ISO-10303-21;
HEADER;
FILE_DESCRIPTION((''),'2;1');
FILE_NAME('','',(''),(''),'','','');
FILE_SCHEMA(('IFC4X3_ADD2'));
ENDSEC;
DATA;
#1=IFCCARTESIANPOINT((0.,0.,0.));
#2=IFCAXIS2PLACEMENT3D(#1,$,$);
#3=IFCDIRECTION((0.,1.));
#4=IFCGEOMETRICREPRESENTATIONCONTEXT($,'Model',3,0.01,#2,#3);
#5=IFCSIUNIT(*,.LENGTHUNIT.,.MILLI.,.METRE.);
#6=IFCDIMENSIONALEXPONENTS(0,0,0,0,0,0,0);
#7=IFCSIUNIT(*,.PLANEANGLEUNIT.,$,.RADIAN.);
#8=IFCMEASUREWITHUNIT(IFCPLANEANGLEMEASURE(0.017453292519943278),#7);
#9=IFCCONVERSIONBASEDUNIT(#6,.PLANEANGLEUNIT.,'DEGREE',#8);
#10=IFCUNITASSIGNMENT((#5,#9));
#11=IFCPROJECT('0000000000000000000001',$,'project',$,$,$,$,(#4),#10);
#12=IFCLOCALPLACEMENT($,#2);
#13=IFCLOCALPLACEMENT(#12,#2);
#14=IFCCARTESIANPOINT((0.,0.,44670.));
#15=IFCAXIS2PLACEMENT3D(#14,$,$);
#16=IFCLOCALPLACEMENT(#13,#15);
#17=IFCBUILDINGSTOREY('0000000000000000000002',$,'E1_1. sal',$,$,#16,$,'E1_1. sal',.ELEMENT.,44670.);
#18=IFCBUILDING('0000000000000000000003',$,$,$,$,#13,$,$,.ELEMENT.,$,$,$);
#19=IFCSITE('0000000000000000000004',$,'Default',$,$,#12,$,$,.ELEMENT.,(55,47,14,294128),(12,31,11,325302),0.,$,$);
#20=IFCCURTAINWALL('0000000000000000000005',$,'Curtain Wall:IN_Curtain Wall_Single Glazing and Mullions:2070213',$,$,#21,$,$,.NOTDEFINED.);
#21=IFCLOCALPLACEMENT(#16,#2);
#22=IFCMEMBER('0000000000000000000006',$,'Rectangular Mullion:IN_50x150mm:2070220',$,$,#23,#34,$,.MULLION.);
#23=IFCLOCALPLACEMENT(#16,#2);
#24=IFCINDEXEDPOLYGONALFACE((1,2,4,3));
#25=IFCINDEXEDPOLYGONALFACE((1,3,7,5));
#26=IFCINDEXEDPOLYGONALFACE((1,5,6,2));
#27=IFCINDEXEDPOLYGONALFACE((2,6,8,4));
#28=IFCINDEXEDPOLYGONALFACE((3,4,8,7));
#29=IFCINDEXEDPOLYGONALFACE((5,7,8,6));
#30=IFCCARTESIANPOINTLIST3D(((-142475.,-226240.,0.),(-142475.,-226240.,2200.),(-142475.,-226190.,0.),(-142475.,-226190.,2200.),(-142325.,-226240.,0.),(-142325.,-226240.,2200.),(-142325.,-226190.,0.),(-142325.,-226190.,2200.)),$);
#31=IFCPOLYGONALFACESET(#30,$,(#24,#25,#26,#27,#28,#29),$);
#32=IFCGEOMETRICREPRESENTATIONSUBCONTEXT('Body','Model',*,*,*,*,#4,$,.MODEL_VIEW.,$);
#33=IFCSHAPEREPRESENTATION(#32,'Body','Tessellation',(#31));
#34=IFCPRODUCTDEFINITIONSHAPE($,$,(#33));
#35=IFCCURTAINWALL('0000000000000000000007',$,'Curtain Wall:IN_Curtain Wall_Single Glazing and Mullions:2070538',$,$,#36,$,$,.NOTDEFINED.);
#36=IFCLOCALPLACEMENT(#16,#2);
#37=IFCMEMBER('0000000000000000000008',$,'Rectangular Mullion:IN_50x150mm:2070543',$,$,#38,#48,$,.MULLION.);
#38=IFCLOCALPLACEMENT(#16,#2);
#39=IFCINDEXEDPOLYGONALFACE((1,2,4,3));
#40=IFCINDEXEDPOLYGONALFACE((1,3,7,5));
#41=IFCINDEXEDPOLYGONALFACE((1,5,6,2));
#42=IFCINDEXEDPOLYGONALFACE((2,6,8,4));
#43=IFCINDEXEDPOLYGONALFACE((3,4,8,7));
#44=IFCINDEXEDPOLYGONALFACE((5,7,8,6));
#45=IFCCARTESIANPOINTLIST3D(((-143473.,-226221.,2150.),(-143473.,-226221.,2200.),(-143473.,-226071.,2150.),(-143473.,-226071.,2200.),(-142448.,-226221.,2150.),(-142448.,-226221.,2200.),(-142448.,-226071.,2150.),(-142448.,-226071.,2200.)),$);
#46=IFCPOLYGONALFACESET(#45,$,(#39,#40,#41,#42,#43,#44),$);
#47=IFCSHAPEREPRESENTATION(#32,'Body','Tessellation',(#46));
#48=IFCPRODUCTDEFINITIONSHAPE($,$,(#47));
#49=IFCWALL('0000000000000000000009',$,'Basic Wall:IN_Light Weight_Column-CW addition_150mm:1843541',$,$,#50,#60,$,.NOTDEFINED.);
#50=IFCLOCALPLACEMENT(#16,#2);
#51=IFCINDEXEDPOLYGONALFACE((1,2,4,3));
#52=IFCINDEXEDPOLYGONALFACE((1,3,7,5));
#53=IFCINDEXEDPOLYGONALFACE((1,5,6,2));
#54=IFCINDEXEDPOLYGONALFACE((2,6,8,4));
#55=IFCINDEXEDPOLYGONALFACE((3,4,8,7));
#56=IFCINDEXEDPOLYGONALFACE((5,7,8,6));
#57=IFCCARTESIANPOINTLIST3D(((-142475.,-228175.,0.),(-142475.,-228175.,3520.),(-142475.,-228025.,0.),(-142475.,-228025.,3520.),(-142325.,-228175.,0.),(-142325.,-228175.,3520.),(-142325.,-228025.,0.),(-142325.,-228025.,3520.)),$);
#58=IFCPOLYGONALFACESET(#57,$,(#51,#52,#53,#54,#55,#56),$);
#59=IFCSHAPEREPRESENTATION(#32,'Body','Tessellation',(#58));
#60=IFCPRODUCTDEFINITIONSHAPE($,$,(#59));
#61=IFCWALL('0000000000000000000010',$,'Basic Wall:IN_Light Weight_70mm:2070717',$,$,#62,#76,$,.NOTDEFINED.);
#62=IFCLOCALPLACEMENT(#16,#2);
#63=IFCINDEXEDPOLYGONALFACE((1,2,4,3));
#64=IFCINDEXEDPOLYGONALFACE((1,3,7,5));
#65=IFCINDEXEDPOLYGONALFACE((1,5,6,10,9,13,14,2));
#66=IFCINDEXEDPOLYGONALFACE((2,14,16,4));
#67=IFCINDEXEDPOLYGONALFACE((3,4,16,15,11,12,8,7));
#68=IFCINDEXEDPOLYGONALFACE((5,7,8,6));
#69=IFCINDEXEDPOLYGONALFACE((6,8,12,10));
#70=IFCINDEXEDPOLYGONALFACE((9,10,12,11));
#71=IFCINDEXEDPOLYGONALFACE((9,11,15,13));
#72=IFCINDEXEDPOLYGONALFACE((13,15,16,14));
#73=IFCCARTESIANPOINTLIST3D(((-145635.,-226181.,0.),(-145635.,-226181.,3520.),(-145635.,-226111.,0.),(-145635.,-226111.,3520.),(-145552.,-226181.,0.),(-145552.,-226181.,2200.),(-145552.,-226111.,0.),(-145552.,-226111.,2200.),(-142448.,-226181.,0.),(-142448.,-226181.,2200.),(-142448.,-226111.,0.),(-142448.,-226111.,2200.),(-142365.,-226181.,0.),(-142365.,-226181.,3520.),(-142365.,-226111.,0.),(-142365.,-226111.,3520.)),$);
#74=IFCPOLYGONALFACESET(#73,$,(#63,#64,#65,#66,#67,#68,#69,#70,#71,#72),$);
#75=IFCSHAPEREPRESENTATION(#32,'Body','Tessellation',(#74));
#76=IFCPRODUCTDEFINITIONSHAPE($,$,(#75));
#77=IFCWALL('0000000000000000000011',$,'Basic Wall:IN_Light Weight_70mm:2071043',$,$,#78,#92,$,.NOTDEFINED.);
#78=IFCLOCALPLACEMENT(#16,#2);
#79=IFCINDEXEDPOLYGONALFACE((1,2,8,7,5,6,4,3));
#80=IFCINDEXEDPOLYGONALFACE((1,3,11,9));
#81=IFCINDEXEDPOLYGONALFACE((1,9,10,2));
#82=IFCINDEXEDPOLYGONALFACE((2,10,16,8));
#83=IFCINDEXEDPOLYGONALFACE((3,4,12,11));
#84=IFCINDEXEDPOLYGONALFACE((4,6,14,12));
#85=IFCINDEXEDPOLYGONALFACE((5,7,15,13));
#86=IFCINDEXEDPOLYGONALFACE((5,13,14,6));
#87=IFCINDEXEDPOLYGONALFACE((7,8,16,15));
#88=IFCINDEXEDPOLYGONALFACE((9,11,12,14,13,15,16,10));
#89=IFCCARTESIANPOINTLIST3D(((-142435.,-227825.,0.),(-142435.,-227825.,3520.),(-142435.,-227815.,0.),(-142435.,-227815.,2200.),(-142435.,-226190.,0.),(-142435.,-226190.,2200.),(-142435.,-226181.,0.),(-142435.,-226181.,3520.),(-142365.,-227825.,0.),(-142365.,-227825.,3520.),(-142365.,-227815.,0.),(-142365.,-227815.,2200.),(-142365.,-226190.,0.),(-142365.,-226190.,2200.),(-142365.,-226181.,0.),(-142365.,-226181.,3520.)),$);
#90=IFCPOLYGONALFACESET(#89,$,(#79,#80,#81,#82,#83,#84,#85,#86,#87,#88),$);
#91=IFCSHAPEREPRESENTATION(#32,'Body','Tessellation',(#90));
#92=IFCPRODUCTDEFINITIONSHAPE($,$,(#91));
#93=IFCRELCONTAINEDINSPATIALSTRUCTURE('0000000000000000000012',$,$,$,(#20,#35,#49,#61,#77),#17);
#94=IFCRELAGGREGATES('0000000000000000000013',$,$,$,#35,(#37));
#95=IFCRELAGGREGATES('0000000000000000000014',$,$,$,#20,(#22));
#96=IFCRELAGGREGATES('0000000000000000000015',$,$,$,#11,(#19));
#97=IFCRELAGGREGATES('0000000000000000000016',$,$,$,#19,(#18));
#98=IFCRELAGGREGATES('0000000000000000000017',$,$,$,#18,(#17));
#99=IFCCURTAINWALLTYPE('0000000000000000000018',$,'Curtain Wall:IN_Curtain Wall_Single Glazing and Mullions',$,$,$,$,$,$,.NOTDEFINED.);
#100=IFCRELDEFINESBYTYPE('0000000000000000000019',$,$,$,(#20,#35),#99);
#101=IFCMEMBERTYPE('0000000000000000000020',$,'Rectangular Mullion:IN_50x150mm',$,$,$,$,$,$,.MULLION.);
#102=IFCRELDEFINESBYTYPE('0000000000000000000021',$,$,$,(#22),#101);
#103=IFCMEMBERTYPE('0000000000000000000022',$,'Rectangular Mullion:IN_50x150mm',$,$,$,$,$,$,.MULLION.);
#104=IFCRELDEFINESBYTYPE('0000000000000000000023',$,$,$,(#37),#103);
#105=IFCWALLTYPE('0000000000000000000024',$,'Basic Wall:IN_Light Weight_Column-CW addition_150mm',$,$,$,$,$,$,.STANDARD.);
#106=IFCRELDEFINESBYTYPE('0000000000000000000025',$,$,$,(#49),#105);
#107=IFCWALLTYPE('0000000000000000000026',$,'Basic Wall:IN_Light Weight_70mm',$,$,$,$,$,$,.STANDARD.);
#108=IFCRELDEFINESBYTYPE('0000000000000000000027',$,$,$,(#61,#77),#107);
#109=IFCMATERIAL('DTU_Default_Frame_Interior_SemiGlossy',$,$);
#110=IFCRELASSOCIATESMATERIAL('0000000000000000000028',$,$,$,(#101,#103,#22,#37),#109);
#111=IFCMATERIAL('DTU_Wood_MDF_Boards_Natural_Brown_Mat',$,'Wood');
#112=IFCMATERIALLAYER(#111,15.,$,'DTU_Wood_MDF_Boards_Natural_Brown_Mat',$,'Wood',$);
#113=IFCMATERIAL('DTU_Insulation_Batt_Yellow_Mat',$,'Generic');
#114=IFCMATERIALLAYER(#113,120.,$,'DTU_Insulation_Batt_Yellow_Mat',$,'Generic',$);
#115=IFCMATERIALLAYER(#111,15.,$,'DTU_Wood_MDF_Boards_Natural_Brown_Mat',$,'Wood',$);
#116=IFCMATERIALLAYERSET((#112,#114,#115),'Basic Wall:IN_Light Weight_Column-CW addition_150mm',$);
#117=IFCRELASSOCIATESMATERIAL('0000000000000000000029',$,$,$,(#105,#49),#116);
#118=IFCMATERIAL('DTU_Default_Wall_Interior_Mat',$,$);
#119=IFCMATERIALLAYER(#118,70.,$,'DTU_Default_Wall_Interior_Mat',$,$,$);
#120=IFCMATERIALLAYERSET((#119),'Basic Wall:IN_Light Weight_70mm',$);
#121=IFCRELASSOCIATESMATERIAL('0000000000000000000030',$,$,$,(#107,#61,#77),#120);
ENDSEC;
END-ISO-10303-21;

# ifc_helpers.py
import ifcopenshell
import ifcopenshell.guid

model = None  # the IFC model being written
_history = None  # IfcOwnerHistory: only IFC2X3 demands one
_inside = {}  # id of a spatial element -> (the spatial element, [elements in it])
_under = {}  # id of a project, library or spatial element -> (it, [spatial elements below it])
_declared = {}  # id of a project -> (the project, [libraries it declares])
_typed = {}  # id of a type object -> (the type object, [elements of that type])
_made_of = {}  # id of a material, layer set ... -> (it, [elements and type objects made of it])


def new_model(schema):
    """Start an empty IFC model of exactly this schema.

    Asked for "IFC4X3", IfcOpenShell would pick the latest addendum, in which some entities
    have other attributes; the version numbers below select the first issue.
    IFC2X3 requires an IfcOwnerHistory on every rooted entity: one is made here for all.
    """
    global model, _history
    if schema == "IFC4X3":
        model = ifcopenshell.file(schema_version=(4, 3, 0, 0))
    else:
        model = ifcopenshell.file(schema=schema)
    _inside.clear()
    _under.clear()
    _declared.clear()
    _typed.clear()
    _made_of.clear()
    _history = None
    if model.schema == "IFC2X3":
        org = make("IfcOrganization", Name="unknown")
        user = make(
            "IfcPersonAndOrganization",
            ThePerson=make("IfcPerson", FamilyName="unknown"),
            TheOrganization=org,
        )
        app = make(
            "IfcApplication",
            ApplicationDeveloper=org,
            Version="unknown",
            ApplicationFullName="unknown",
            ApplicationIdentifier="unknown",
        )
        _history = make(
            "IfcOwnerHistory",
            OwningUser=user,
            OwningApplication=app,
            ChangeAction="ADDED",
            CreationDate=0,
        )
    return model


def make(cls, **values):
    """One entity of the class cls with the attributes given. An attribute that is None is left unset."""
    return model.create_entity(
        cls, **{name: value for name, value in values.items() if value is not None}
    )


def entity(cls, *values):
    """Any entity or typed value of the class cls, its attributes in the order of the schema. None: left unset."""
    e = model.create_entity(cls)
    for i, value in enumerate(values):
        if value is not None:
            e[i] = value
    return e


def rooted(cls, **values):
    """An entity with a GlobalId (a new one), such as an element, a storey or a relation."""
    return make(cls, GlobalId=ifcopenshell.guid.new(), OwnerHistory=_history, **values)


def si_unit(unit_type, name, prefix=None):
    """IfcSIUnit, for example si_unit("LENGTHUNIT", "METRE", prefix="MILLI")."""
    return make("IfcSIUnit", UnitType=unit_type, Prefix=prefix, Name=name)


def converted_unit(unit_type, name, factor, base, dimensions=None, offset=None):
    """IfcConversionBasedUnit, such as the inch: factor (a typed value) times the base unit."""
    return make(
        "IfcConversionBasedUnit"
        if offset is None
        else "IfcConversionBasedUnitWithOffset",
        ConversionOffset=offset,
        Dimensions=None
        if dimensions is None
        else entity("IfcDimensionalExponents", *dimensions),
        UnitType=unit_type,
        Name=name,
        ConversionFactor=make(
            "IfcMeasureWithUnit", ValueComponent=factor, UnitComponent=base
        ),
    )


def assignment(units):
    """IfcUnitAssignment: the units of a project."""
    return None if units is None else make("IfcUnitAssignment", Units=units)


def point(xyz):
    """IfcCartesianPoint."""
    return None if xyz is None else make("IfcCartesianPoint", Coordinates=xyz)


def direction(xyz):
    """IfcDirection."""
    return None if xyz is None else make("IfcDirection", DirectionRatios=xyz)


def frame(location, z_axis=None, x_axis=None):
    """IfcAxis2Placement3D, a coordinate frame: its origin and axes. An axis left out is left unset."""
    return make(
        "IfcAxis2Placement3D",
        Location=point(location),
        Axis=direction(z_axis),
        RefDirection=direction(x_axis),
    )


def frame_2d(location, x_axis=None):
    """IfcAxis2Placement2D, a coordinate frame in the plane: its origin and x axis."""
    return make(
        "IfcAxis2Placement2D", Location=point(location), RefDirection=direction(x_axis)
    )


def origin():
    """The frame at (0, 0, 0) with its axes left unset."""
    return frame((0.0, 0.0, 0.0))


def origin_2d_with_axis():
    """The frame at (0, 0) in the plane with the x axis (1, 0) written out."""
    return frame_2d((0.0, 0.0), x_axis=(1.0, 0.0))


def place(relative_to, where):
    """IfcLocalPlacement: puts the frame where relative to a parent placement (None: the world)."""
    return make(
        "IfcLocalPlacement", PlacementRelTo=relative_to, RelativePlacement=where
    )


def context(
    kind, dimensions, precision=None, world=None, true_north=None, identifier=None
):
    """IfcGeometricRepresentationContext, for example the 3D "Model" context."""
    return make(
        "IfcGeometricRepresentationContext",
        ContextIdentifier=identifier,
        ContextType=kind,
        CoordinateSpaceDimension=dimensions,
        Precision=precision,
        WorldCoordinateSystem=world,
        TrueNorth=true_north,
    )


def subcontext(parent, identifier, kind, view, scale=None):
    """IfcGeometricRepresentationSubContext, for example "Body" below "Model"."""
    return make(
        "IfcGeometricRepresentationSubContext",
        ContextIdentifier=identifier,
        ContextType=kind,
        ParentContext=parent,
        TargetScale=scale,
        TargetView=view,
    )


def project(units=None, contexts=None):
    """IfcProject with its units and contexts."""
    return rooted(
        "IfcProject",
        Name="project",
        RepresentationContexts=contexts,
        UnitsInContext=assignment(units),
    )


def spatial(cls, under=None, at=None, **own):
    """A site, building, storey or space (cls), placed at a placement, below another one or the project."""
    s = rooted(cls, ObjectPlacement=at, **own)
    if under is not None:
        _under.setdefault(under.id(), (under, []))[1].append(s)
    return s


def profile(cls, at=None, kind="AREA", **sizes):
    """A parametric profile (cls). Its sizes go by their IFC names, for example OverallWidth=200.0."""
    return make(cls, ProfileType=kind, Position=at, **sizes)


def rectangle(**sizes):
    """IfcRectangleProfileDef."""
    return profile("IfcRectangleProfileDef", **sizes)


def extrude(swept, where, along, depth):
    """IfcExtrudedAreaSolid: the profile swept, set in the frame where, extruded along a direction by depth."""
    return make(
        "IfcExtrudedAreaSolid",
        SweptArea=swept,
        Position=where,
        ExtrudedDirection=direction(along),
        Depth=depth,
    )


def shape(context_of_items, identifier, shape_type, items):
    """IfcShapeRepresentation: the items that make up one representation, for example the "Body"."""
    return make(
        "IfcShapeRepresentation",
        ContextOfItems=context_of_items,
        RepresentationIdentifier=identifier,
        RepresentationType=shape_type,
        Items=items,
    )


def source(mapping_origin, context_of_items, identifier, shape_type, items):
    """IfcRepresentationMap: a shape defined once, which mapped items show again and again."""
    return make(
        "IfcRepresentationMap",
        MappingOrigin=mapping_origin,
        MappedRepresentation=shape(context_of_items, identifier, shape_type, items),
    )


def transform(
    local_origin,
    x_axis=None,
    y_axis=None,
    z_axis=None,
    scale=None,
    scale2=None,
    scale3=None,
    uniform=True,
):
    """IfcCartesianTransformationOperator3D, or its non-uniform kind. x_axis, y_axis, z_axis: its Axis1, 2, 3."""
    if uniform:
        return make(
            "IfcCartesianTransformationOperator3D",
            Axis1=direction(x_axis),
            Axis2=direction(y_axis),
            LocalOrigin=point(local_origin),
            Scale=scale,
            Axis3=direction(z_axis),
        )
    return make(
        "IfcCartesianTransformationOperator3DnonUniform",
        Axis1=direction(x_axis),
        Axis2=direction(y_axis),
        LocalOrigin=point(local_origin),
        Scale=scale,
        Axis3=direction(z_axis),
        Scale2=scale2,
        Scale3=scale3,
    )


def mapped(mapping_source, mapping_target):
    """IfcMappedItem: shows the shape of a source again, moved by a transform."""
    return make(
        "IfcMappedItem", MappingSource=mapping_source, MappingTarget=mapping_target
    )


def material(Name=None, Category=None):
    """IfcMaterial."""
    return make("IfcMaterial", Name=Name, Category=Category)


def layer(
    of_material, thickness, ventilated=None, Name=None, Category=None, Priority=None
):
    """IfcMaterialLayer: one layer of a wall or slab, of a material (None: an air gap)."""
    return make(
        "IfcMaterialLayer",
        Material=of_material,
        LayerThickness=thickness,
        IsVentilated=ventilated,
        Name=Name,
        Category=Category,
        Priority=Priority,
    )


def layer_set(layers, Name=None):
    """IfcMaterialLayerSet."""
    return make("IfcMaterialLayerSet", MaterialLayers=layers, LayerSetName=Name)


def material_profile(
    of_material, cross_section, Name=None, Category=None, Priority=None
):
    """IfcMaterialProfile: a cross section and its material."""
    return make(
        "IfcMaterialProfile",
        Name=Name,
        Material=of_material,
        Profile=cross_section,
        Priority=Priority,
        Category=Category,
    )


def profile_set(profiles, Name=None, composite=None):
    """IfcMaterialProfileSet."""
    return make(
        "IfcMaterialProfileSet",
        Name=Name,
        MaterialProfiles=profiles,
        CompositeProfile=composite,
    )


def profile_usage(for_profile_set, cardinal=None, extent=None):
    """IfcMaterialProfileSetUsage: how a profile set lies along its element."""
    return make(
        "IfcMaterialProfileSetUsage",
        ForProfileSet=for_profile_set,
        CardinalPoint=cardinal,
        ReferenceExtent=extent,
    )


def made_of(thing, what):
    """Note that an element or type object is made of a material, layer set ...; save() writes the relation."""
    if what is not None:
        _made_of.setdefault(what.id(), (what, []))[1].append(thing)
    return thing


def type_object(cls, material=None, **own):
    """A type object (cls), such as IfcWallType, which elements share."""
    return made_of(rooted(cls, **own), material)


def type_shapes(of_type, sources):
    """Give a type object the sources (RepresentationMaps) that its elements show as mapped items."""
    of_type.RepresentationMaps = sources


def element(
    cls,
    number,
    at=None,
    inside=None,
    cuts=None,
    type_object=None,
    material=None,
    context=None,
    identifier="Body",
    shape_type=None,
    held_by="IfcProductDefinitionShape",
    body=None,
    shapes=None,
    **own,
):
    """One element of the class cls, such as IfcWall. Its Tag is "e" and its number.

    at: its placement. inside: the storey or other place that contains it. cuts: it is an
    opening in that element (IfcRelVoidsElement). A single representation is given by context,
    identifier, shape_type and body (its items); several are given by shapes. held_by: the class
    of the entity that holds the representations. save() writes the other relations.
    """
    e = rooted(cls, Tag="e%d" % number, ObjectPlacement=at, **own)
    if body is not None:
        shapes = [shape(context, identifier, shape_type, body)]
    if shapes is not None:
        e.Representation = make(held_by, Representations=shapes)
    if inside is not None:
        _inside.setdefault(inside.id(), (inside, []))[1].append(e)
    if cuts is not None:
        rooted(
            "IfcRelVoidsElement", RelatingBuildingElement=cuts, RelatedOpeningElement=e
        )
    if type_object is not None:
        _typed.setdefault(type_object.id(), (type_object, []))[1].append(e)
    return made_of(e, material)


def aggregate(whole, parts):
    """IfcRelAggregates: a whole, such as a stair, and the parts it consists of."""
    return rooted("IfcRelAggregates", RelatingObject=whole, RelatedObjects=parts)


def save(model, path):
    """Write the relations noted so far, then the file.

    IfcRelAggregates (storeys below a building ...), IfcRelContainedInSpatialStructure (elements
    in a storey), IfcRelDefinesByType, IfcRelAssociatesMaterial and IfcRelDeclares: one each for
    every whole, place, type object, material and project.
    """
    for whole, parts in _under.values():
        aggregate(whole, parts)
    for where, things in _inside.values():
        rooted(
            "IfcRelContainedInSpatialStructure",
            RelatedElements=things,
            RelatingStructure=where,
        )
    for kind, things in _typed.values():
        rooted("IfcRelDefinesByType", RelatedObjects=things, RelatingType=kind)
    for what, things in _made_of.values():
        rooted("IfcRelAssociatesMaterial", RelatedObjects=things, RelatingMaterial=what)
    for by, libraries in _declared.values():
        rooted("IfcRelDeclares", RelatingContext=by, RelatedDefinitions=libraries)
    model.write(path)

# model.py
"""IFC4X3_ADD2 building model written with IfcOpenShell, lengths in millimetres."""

from ifc_helpers import new_model, entity, si_unit, converted_unit, direction, frame, frame_2d, origin, origin_2d_with_axis, place, context, subcontext, project, spatial, rectangle, extrude, source, transform, mapped, material, layer, layer_set, material_profile, profile_set, profile_usage, type_object, type_shapes, element, aggregate, save


model = new_model("IFC4X3_ADD2")

# Units and contexts
model_context = context("Model", 3, precision=0.01, world=origin(), true_north=direction((0.0, 1.0)))
body_context = subcontext(model_context, "Body", "Model", "MODEL_VIEW")
ifc_project = project(units=[si_unit("LENGTHUNIT", "METRE", prefix="MILLI"), converted_unit("PLANEANGLEUNIT", "DEGREE", entity("IfcPlaneAngleMeasure", 0.017453292519943278), si_unit("PLANEANGLEUNIT", "RADIAN"), dimensions=[0, 0, 0, 0, 0, 0, 0])], contexts=[model_context])

# Site, building, storey
site_placement = place(None, origin())
site = spatial("IfcSite", under=ifc_project, at=site_placement, Name="Default", CompositionType="ELEMENT", RefLatitude=(55, 47, 14, 294128), RefLongitude=(12, 31, 11, 325302), RefElevation=0.0)
building_placement = place(site_placement, origin())
building = spatial("IfcBuilding", under=site, at=building_placement, CompositionType="ELEMENT")
storey_placement = place(building_placement, frame((0.0, 0.0, 44670.0)))
storey = spatial("IfcBuildingStorey", under=building, at=storey_placement, Name="E1_1. sal", LongName="E1_1. sal", CompositionType="ELEMENT", Elevation=44670.0)

# Curtain wall, member
curtain_wall_type_1 = type_object("IfcCurtainWallType", Name="Curtain Wall:IN_Curtain Wall_Single Glazing and Mullions", PredefinedType="NOTDEFINED")
curtain_wall_1_placement = place(storey_placement, frame((0.0, 0.0, -44670.0)))
curtain_wall_1 = element("IfcCurtainWall", 1, at=curtain_wall_1_placement, inside=storey, type_object=curtain_wall_type_1, Name="Curtain Wall:IN_Curtain Wall_Single Glazing and Mullions:2070213", PredefinedType="NOTDEFINED")
ifc_material_1 = material(Name="DTU_Default_Frame_Interior_SemiGlossy")
ifc_material_profile_1 = material_profile(ifc_material_1, rectangle(XDim=50.0, YDim=150.0, at=origin_2d_with_axis()), Name="IN_50x150mm")
ifc_profile_set_1 = profile_set([ifc_material_profile_1], Name="IN_50x150mm")
ifc_profile_usage_1 = profile_usage(ifc_profile_set_1)
member_type_1 = type_object("IfcMemberType", Name="Rectangular Mullion:IN_50x150mm", PredefinedType="MULLION", material=ifc_profile_set_1)
shared_shape_1 = source(origin(), body_context, "Body", "SweptSolid", [
    extrude(rectangle(XDim=50.0, YDim=150.0, at=origin_2d_with_axis()), frame((-25.0, 0.0, -2200.0), z_axis=(0.0, 0.0, 1.0), x_axis=(-1.0, 0.0, 0.0)), (0.0, 0.0, 1.0), 2200.0),
])
type_shapes(member_type_1, [shared_shape_1])
member_1_placement = place(curtain_wall_1_placement, frame((-142400.0, -226190.0, 46870.0), z_axis=(0.0, 0.0, 1.0), x_axis=(0.0, 1.0, 0.0)))
member_1 = element("IfcMember", 2, at=member_1_placement, type_object=member_type_1, material=ifc_profile_usage_1, Name="Rectangular Mullion:IN_50x150mm:2070220", PredefinedType="MULLION", context=body_context, shape_type="MappedRepresentation", body=[
    mapped(shared_shape_1, transform((0.0, 0.0, 0.0), scale=1.0)),
])

# Curtain wall, member
curtain_wall_2_placement = place(storey_placement, frame((0.0, 0.0, -44670.0)))
curtain_wall_2 = element("IfcCurtainWall", 3, at=curtain_wall_2_placement, inside=storey, type_object=curtain_wall_type_1, Name="Curtain Wall:IN_Curtain Wall_Single Glazing and Mullions:2070538", PredefinedType="NOTDEFINED")
member_type_2 = type_object("IfcMemberType", Name="Rectangular Mullion:IN_50x150mm", PredefinedType="MULLION", material=ifc_profile_set_1)
shared_shape_2 = source(origin(), body_context, "Body", "SweptSolid", [
    extrude(rectangle(XDim=50.0, YDim=150.0, at=origin_2d_with_axis()), frame((-25.0, 0.0, -1025.0), z_axis=(0.0, 0.0, 1.0), x_axis=(-1.0, 0.0, 0.0)), (0.0, 0.0, 1.0), 1025.0),
])
type_shapes(member_type_2, [shared_shape_2])
member_2_placement = place(curtain_wall_2_placement, frame((-142448.0, -226146.0, 46870.0), z_axis=(1.0, 0.0, 0.0), x_axis=(0.0, 0.0, 1.0)))
member_2 = element("IfcMember", 4, at=member_2_placement, type_object=member_type_2, material=ifc_profile_usage_1, Name="Rectangular Mullion:IN_50x150mm:2070543", PredefinedType="MULLION", context=body_context, shape_type="MappedRepresentation", body=[
    mapped(shared_shape_2, transform((0.0, 0.0, 0.0), scale=1.0)),
])
aggregate(curtain_wall_2, [member_2])

aggregate(curtain_wall_1, [member_1])

# Wall
ifc_material_2 = material(Name="DTU_Wood_MDF_Boards_Natural_Brown_Mat", Category="Wood")
ifc_layer_1 = layer(ifc_material_2, 15.0, Name="DTU_Wood_MDF_Boards_Natural_Brown_Mat", Category="Wood")
ifc_material_3 = material(Name="DTU_Insulation_Batt_Yellow_Mat", Category="Generic")
ifc_layer_2 = layer(ifc_material_3, 120.0, Name="DTU_Insulation_Batt_Yellow_Mat", Category="Generic")
ifc_layer_3 = layer(ifc_material_2, 15.0, Name="DTU_Wood_MDF_Boards_Natural_Brown_Mat", Category="Wood")
ifc_layer_set_1 = layer_set([ifc_layer_1, ifc_layer_2, ifc_layer_3], Name="Basic Wall:IN_Light Weight_Column-CW addition_150mm")
wall_type_1 = type_object("IfcWallType", Name="Basic Wall:IN_Light Weight_Column-CW addition_150mm", PredefinedType="STANDARD", material=ifc_layer_set_1)
wall_1_placement = place(storey_placement, frame((-142400.0, -228025.0, 0.0), z_axis=(0.0, 0.0, 1.0), x_axis=(0.0, -1.0, 0.0)))
element("IfcWall", 5, at=wall_1_placement, inside=storey, type_object=wall_type_1, material=ifc_layer_set_1, Name="Basic Wall:IN_Light Weight_Column-CW addition_150mm:1843541", PredefinedType="NOTDEFINED", context=body_context, shape_type="SweptSolid", body=[
    extrude(rectangle(XDim=150.0, YDim=150.0, at=frame_2d((75.0, 0.0), x_axis=(-1.0, 0.0))), origin(), (0.0, 0.0, 1.0), 3520.0),
])

# Walls, openings
ifc_material_4 = material(Name="DTU_Default_Wall_Interior_Mat")
ifc_layer_4 = layer(ifc_material_4, 70.0, Name="DTU_Default_Wall_Interior_Mat")
ifc_layer_set_2 = layer_set([ifc_layer_4], Name="Basic Wall:IN_Light Weight_70mm")
wall_type_2 = type_object("IfcWallType", Name="Basic Wall:IN_Light Weight_70mm", PredefinedType="STANDARD", material=ifc_layer_set_2)
wall_2_placement = place(storey_placement, frame((-142365.0, -226146.0, 0.0), z_axis=(0.0, 0.0, 1.0), x_axis=(-1.0, 0.0, 0.0)))
wall_2 = element("IfcWall", 6, at=wall_2_placement, inside=storey, type_object=wall_type_2, material=ifc_layer_set_2, Name="Basic Wall:IN_Light Weight_70mm:2070717", PredefinedType="NOTDEFINED", context=body_context, shape_type="SweptSolid", body=[
    extrude(rectangle(XDim=3270.0, YDim=70.0, at=frame_2d((1635.0, 0.0), x_axis=(-1.0, 0.0))), origin(), (0.0, 0.0, 1.0), 3520.0),
])
opening_1_placement = place(wall_2_placement, frame((3187.0, 187.4, 0.0)))
element("IfcOpeningElement", 7, at=opening_1_placement, cuts=wall_2, PredefinedType="OPENING", context=body_context, shape_type="SweptSolid", body=[
    extrude(rectangle(XDim=2200.0, YDim=3104.0, at=frame_2d((0.0, 0.0), x_axis=(0.0, 1.0))), frame((-1552.0, -374.8, 1100.0), z_axis=(0.0, 1.0, 0.0), x_axis=(-1.0, 0.0, 0.0)), (0.0, 0.0, 1.0), 374.8),
])
wall_3_placement = place(storey_placement, frame((-142400.0, -226181.0, 0.0), z_axis=(0.0, 0.0, 1.0), x_axis=(0.0, -1.0, 0.0)))
wall_3 = element("IfcWall", 8, at=wall_3_placement, inside=storey, type_object=wall_type_2, material=ifc_layer_set_2, Name="Basic Wall:IN_Light Weight_70mm:2071043", PredefinedType="NOTDEFINED", context=body_context, shape_type="SweptSolid", body=[
    extrude(rectangle(XDim=1644.0, YDim=70.0, at=frame_2d((822.0, 0.0), x_axis=(1.0, 0.0))), origin(), (0.0, 0.0, 1.0), 3520.0),
])
opening_2_placement = place(wall_3_placement, frame((1634.0, -187.4, 0.0)))
element("IfcOpeningElement", 9, at=opening_2_placement, cuts=wall_3, PredefinedType="OPENING", context=body_context, shape_type="SweptSolid", body=[
    extrude(rectangle(XDim=2200.0, YDim=1625.0, at=origin_2d_with_axis()), frame((-812.5, 0.0, 1100.0), z_axis=(0.0, 1.0, 0.0), x_axis=(0.0, 0.0, 1.0)), (0.0, 0.0, 1.0), 374.8),
])

save(model, "model.ifc")
